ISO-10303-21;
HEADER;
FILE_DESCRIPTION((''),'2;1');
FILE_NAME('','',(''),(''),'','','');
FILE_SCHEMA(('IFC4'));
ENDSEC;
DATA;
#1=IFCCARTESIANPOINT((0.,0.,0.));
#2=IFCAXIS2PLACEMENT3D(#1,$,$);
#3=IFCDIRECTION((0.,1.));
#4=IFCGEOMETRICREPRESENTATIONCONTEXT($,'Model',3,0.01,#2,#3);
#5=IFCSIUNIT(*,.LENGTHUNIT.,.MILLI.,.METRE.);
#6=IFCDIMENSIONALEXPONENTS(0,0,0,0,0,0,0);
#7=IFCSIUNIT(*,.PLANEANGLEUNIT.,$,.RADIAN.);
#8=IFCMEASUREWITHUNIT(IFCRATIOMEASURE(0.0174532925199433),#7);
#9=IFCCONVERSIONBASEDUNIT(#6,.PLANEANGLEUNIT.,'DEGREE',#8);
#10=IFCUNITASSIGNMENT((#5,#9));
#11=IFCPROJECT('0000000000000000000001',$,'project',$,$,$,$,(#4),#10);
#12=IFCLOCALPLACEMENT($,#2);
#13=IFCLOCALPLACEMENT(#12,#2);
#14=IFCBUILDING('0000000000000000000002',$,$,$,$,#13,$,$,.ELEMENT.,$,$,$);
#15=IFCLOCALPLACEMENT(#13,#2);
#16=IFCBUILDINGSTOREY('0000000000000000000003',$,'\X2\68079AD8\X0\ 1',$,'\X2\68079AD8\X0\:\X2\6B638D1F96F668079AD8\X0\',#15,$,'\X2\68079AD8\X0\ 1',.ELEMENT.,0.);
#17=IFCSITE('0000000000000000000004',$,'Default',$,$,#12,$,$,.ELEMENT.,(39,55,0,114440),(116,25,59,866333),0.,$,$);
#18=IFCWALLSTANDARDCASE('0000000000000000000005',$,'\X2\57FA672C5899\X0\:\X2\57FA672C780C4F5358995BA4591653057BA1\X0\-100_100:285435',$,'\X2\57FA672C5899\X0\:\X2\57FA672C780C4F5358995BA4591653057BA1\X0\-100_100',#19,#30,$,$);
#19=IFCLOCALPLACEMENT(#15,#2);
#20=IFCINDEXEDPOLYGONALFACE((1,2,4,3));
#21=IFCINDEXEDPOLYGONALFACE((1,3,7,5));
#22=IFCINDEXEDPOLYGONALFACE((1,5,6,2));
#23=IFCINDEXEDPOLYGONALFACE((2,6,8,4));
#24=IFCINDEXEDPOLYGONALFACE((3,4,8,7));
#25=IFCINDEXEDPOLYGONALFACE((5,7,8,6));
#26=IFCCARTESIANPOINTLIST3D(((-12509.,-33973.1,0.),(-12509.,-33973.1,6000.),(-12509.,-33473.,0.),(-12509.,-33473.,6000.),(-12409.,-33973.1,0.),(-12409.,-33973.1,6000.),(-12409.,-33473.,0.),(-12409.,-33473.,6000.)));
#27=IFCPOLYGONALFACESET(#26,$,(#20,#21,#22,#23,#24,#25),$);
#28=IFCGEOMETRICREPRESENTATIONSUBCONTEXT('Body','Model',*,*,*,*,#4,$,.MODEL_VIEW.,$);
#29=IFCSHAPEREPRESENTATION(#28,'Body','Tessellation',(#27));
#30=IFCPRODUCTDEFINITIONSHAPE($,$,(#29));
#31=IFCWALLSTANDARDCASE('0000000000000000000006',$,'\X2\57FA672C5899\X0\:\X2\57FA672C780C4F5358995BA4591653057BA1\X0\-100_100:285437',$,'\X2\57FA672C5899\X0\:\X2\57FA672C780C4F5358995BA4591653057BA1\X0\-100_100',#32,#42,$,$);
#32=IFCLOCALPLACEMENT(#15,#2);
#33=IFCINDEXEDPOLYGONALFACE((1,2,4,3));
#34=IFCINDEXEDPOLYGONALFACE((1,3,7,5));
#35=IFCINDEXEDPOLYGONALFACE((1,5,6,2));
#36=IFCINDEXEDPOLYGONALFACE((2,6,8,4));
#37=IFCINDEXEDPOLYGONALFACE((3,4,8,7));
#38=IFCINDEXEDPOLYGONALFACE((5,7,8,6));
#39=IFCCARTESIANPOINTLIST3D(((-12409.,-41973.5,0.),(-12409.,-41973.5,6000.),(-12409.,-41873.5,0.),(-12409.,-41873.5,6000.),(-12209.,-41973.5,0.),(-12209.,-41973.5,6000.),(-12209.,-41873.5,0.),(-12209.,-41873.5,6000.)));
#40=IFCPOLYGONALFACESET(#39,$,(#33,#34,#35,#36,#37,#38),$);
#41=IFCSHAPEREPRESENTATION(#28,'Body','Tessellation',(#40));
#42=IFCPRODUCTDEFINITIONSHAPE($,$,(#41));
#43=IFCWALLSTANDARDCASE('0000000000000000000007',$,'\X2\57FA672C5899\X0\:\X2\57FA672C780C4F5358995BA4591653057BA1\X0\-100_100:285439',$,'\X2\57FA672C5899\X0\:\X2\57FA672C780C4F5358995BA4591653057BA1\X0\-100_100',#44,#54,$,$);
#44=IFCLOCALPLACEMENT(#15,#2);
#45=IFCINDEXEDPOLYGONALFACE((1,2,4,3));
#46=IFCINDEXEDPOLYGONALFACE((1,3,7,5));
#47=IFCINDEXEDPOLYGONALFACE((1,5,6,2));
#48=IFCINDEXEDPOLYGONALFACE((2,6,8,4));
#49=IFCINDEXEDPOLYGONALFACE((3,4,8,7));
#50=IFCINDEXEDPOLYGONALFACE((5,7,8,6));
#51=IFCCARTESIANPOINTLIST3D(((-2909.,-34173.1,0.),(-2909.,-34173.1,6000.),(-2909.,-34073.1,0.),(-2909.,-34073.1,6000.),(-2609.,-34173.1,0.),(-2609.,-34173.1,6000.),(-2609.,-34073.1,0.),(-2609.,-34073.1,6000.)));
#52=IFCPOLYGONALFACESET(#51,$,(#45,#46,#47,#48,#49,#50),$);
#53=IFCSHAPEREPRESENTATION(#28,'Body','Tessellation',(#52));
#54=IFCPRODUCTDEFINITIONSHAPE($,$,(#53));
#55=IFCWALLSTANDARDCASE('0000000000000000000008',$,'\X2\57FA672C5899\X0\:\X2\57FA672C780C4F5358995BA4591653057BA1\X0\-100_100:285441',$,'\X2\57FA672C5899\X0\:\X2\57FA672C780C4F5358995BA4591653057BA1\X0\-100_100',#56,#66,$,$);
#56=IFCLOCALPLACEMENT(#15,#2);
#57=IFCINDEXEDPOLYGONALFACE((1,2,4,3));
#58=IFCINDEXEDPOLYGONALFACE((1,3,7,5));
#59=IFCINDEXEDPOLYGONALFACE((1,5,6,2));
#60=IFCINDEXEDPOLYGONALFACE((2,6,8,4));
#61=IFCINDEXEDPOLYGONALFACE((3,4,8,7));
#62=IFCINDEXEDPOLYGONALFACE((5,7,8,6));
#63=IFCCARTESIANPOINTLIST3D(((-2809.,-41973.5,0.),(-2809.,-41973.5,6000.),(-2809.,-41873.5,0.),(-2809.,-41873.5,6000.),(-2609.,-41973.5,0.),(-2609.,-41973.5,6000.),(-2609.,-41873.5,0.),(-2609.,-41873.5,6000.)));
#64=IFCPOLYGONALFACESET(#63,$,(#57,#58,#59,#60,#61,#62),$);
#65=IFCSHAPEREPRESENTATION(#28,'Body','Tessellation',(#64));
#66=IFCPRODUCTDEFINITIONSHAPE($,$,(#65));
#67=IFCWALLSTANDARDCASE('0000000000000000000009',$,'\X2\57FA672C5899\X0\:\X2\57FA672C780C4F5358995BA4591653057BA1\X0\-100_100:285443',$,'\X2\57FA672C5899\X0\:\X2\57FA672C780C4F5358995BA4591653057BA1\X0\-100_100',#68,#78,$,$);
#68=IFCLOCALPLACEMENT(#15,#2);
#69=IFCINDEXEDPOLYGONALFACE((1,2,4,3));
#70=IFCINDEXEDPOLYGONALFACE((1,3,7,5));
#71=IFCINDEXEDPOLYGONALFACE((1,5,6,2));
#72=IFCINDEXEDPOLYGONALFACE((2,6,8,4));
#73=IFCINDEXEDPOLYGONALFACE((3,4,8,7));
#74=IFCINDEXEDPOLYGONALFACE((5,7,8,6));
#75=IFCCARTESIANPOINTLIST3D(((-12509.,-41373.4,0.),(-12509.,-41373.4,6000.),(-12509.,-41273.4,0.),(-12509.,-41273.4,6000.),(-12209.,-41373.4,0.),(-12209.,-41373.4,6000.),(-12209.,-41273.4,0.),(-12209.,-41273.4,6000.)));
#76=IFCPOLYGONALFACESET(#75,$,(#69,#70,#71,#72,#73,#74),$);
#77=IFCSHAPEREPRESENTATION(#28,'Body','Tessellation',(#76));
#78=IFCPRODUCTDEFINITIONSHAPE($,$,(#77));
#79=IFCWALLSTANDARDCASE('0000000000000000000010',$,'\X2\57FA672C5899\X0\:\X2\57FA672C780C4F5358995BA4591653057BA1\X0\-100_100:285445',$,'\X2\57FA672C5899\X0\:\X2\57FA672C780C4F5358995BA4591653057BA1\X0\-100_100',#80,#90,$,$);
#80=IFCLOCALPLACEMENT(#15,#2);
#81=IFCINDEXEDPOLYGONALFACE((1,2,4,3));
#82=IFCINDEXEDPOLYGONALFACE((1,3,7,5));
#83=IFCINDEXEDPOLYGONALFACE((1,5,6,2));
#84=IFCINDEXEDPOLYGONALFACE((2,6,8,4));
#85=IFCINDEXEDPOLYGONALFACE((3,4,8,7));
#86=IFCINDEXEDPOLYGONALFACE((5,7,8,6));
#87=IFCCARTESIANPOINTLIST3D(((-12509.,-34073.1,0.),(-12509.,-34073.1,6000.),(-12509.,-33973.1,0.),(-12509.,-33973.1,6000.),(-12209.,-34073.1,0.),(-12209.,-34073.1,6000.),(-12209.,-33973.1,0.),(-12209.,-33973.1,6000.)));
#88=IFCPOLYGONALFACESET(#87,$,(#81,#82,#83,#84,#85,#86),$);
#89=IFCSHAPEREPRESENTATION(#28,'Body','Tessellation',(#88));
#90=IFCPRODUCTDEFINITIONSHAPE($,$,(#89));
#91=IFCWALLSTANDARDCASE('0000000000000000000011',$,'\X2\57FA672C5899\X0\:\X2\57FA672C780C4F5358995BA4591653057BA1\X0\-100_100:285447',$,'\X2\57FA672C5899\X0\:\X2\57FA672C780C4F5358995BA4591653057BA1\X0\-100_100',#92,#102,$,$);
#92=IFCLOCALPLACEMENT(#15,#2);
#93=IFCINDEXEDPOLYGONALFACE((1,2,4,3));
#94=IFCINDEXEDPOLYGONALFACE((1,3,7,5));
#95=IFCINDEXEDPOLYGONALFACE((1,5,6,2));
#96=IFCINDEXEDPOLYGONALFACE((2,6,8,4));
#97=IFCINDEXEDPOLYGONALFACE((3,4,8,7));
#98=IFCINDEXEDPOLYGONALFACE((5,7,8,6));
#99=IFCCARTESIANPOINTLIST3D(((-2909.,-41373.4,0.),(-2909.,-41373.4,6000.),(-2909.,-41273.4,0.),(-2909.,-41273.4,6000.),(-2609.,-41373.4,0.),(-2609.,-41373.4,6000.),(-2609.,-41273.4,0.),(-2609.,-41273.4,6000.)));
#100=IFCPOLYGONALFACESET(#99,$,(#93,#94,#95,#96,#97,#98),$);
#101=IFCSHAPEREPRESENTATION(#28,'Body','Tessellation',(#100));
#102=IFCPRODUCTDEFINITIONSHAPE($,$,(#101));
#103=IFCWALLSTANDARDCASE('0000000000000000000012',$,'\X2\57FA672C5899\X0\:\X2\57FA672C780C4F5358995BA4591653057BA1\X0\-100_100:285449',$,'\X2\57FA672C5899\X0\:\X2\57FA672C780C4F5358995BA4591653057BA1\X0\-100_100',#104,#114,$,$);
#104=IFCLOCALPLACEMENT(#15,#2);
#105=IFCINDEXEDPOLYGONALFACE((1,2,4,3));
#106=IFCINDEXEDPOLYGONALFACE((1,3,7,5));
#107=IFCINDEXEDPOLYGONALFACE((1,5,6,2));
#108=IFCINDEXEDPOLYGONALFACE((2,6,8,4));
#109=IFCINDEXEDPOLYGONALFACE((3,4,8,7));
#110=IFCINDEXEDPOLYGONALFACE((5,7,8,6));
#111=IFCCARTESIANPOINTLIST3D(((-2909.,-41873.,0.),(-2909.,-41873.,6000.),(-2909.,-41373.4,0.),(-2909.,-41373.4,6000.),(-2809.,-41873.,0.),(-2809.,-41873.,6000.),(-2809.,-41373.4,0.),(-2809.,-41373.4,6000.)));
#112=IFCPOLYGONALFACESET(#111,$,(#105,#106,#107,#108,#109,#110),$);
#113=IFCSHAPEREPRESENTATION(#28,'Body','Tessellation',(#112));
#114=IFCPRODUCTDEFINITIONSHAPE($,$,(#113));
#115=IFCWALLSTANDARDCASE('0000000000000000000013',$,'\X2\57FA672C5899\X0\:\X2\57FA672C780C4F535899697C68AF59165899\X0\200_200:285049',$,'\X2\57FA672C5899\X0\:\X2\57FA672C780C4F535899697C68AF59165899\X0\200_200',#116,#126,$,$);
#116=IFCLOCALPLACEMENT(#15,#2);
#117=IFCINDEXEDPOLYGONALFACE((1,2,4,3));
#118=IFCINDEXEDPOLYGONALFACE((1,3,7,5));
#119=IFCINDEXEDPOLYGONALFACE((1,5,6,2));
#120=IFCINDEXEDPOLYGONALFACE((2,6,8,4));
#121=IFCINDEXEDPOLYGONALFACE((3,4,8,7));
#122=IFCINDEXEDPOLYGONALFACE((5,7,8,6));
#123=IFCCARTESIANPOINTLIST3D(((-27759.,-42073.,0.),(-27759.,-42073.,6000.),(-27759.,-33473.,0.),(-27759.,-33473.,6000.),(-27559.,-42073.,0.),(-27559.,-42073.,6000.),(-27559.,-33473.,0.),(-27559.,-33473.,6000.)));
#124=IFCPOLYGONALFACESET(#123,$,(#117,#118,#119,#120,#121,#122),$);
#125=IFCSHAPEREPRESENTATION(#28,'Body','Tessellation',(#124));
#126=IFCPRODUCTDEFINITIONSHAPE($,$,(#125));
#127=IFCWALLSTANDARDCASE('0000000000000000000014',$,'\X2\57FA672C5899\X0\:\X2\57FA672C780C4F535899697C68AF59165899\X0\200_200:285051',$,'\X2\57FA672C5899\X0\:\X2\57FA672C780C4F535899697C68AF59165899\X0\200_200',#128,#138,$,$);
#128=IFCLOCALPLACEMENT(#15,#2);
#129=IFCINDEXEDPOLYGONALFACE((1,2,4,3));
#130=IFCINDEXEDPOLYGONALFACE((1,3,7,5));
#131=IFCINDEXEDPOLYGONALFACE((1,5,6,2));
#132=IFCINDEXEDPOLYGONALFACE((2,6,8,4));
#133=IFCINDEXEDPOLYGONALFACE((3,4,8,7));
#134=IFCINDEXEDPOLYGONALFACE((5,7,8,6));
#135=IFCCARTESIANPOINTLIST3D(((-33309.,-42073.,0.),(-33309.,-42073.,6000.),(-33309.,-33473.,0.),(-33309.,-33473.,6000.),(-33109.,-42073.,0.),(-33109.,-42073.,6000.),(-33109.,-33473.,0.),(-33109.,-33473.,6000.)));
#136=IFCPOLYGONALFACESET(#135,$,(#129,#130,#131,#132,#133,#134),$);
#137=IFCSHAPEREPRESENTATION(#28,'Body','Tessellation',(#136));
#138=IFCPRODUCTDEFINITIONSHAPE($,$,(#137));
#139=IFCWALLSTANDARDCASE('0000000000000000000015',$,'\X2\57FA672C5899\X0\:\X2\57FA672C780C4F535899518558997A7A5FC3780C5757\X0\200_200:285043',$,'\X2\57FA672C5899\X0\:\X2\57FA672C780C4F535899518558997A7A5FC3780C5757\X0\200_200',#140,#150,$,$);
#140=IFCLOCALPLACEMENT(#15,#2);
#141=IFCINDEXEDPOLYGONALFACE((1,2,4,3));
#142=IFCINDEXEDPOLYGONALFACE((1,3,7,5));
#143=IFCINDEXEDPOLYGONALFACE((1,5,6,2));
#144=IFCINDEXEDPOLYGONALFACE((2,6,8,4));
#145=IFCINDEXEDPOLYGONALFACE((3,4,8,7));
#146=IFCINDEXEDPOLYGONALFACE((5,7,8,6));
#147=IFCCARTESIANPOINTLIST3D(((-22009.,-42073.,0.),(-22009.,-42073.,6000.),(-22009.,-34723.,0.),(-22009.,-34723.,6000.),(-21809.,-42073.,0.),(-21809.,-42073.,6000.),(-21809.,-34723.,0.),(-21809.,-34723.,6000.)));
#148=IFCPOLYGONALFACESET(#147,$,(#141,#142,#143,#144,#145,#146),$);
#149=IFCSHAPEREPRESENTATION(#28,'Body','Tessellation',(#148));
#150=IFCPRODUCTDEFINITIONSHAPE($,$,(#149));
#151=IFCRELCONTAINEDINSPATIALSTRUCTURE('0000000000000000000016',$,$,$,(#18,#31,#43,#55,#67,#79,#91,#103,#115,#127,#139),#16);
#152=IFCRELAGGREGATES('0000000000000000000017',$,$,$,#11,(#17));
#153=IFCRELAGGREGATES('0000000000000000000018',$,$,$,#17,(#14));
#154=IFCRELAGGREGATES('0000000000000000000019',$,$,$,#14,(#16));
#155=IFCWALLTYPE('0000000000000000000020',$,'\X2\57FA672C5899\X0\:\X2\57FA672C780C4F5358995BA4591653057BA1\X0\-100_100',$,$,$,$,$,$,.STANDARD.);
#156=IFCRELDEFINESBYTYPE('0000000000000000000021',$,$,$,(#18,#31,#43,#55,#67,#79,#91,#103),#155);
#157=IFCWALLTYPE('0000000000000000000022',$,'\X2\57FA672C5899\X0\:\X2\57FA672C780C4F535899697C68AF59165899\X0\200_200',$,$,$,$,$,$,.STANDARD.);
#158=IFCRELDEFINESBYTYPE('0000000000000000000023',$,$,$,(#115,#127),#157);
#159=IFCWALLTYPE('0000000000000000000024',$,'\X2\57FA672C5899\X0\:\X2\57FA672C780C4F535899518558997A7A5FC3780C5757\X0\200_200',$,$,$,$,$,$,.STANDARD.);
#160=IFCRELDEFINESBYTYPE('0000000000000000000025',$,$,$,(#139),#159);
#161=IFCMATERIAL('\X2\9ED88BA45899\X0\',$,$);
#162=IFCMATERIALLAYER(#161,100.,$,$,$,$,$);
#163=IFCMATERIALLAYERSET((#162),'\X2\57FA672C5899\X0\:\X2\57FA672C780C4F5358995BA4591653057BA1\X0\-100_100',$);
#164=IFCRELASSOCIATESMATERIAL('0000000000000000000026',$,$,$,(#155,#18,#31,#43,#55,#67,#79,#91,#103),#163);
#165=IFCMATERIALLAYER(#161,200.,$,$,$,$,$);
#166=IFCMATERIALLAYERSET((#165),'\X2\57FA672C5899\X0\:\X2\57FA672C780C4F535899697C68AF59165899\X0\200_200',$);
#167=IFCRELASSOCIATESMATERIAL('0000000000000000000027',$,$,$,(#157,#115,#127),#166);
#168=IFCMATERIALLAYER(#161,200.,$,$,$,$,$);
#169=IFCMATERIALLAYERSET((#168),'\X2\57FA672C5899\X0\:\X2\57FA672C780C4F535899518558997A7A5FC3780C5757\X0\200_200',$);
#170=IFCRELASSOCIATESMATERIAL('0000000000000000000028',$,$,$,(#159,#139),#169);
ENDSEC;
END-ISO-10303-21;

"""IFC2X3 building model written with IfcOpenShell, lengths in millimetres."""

from ifc_helpers import new_model, entity, si_unit, converted_unit, direction, frame, frame_2d, origin, place, context, subcontext, project, spatial, rectangle, extrude, material, layer, layer_set, layer_usage, type_object, element, save


model = new_model("IFC2X3")

# Units and contexts
model_context = context("Model", 3, precision=0.01, world=origin(), true_north=direction((0.0, 1.0)))
body_context = subcontext(model_context, "Body", "Model", "MODEL_VIEW")
ifc_project = project(units=[si_unit("LENGTHUNIT", "METRE", prefix="MILLI"), converted_unit("PLANEANGLEUNIT", "DEGREE", entity("IfcRatioMeasure", 0.0174532925199433), si_unit("PLANEANGLEUNIT", "RADIAN"), dimensions=[0, 0, 0, 0, 0, 0, 0])], contexts=[model_context])

# Site, building, storey
site_placement = place(None, origin())
site = spatial("IfcSite", under=ifc_project, at=site_placement, Name="Default", CompositionType="ELEMENT", RefLatitude=(39, 55, 0, 114440), RefLongitude=(116, 25, 59, 866333), RefElevation=0.0)
building_placement = place(site_placement, origin())
building = spatial("IfcBuilding", under=site, at=building_placement, CompositionType="ELEMENT")
storey_placement = place(building_placement, origin())
storey = spatial("IfcBuildingStorey", under=building, at=storey_placement, Name="标高 1", ObjectType="标高:正负零标高", LongName="标高 1", CompositionType="ELEMENT", Elevation=0.0)

# Walls
ifc_material = material(Name="默认墙")
ifc_layer_1 = layer(ifc_material, 100.0)
ifc_layer_set_1 = layer_set([ifc_layer_1], Name="基本墙:基本砌体墙室外包管-100_100")
wall_type_1 = type_object("IfcWallType", Name="基本墙:基本砌体墙室外包管-100_100", PredefinedType="STANDARD", material=ifc_layer_set_1)
ifc_layer_usage_1 = layer_usage(ifc_layer_set_1, "AXIS2", "NEGATIVE", 50.0)
wall_1_placement = place(building_placement, frame((-12459.0, -33473.0, 0.0), z_axis=(0.0, 0.0, 1.0), x_axis=(0.0, -1.0, 0.0)))
element("IfcWallStandardCase", 1, at=wall_1_placement, inside=storey, type_object=wall_type_1, material=ifc_layer_usage_1, Name="基本墙:基本砌体墙室外包管-100_100:285435", ObjectType="基本墙:基本砌体墙室外包管-100_100", context=body_context, shape_type="SweptSolid", body=[
    extrude(rectangle(XDim=500.1, YDim=100.0, at=frame_2d((250.0, 0.0), x_axis=(-1.0, 0.0))), origin(), (0.0, 0.0, 1.0), 6000.0),
])
ifc_layer_usage_2 = layer_usage(ifc_layer_set_1, "AXIS2", "NEGATIVE", 50.0)
wall_2_placement = place(building_placement, frame((-12409.0, -41923.5, 0.0)))
element("IfcWallStandardCase", 2, at=wall_2_placement, inside=storey, type_object=wall_type_1, material=ifc_layer_usage_2, Name="基本墙:基本砌体墙室外包管-100_100:285437", ObjectType="基本墙:基本砌体墙室外包管-100_100", context=body_context, shape_type="SweptSolid", body=[
    extrude(rectangle(XDim=200.0, YDim=100.0, at=frame_2d((100.0, 0.0), x_axis=(-1.0, 0.0))), origin(), (0.0, 0.0, 1.0), 6000.0),
])
ifc_layer_usage_3 = layer_usage(ifc_layer_set_1, "AXIS2", "NEGATIVE", 50.0)
wall_3_placement = place(building_placement, frame((-2909.0, -34123.1, 0.0)))
element("IfcWallStandardCase", 3, at=wall_3_placement, inside=storey, type_object=wall_type_1, material=ifc_layer_usage_3, Name="基本墙:基本砌体墙室外包管-100_100:285439", ObjectType="基本墙:基本砌体墙室外包管-100_100", context=body_context, shape_type="SweptSolid", body=[
    extrude(rectangle(XDim=300.0, YDim=100.0, at=frame_2d((150.0, 0.0), x_axis=(-1.0, 0.0))), origin(), (0.0, 0.0, 1.0), 6000.0),
])
ifc_layer_usage_4 = layer_usage(ifc_layer_set_1, "AXIS2", "NEGATIVE", 50.0)
wall_4_placement = place(building_placement, frame((-2809.0, -41923.5, 0.0)))
element("IfcWallStandardCase", 4, at=wall_4_placement, inside=storey, type_object=wall_type_1, material=ifc_layer_usage_4, Name="基本墙:基本砌体墙室外包管-100_100:285441", ObjectType="基本墙:基本砌体墙室外包管-100_100", context=body_context, shape_type="SweptSolid", body=[
    extrude(rectangle(XDim=200.0, YDim=100.0, at=frame_2d((100.0, 0.0), x_axis=(-1.0, 0.0))), origin(), (0.0, 0.0, 1.0), 6000.0),
])
ifc_layer_usage_5 = layer_usage(ifc_layer_set_1, "AXIS2", "NEGATIVE", 50.0)
wall_5_placement = place(building_placement, frame((-12509.0, -41323.4, 0.0)))
element("IfcWallStandardCase", 5, at=wall_5_placement, inside=storey, type_object=wall_type_1, material=ifc_layer_usage_5, Name="基本墙:基本砌体墙室外包管-100_100:285443", ObjectType="基本墙:基本砌体墙室外包管-100_100", context=body_context, shape_type="SweptSolid", body=[
    extrude(rectangle(XDim=300.0, YDim=100.0, at=frame_2d((150.0, 0.0), x_axis=(-1.0, 0.0))), origin(), (0.0, 0.0, 1.0), 6000.0),
])
ifc_layer_usage_6 = layer_usage(ifc_layer_set_1, "AXIS2", "NEGATIVE", 50.0)
wall_6_placement = place(building_placement, frame((-12509.0, -34023.1, 0.0)))
element("IfcWallStandardCase", 6, at=wall_6_placement, inside=storey, type_object=wall_type_1, material=ifc_layer_usage_6, Name="基本墙:基本砌体墙室外包管-100_100:285445", ObjectType="基本墙:基本砌体墙室外包管-100_100", context=body_context, shape_type="SweptSolid", body=[
    extrude(rectangle(XDim=300.0, YDim=100.0, at=frame_2d((150.0, 0.0), x_axis=(-1.0, 0.0))), origin(), (0.0, 0.0, 1.0), 6000.0),
])
ifc_layer_usage_7 = layer_usage(ifc_layer_set_1, "AXIS2", "NEGATIVE", 50.0)
wall_7_placement = place(building_placement, frame((-2909.0, -41323.4, 0.0)))
element("IfcWallStandardCase", 7, at=wall_7_placement, inside=storey, type_object=wall_type_1, material=ifc_layer_usage_7, Name="基本墙:基本砌体墙室外包管-100_100:285447", ObjectType="基本墙:基本砌体墙室外包管-100_100", context=body_context, shape_type="SweptSolid", body=[
    extrude(rectangle(XDim=300.0, YDim=100.0, at=frame_2d((150.0, 0.0), x_axis=(-1.0, 0.0))), origin(), (0.0, 0.0, 1.0), 6000.0),
])
ifc_layer_usage_8 = layer_usage(ifc_layer_set_1, "AXIS2", "NEGATIVE", 50.0)
wall_8_placement = place(building_placement, frame((-2859.0, -41373.4, 0.0), z_axis=(0.0, 0.0, 1.0), x_axis=(0.0, -1.0, 0.0)))
element("IfcWallStandardCase", 8, at=wall_8_placement, inside=storey, type_object=wall_type_1, material=ifc_layer_usage_8, Name="基本墙:基本砌体墙室外包管-100_100:285449", ObjectType="基本墙:基本砌体墙室外包管-100_100", context=body_context, shape_type="SweptSolid", body=[
    extrude(rectangle(XDim=499.6, YDim=100.0, at=frame_2d((249.8, 0.0), x_axis=(-1.0, 0.0))), origin(), (0.0, 0.0, 1.0), 6000.0),
])
ifc_layer_2 = layer(ifc_material, 200.0)
ifc_layer_set_2 = layer_set([ifc_layer_2], Name="基本墙:基本砌体墙楼梯外墙200_200")
ifc_layer_usage_9 = layer_usage(ifc_layer_set_2, "AXIS2", "NEGATIVE", 100.0)
wall_type_2 = type_object("IfcWallType", Name="基本墙:基本砌体墙楼梯外墙200_200", PredefinedType="STANDARD", material=ifc_layer_set_2)
wall_9_placement = place(building_placement, frame((-27659.0, -42073.0, 0.0), z_axis=(0.0, 0.0, 1.0), x_axis=(0.0, 1.0, 0.0)))
element("IfcWallStandardCase", 9, at=wall_9_placement, inside=storey, type_object=wall_type_2, material=ifc_layer_usage_9, Name="基本墙:基本砌体墙楼梯外墙200_200:285049", ObjectType="基本墙:基本砌体墙楼梯外墙200_200", context=body_context, shape_type="SweptSolid", body=[
    extrude(rectangle(XDim=8600.0, YDim=200.0, at=frame_2d((4300.0, 0.0), x_axis=(-1.0, 0.0))), origin(), (0.0, 0.0, 1.0), 6000.0),
])
ifc_layer_usage_10 = layer_usage(ifc_layer_set_2, "AXIS2", "NEGATIVE", 100.0)
wall_10_placement = place(building_placement, frame((-33209.0, -42073.0, 0.0), z_axis=(0.0, 0.0, 1.0), x_axis=(0.0, 1.0, 0.0)))
element("IfcWallStandardCase", 10, at=wall_10_placement, inside=storey, type_object=wall_type_2, material=ifc_layer_usage_10, Name="基本墙:基本砌体墙楼梯外墙200_200:285051", ObjectType="基本墙:基本砌体墙楼梯外墙200_200", context=body_context, shape_type="SweptSolid", body=[
    extrude(rectangle(XDim=8600.0, YDim=200.0, at=frame_2d((4300.0, 0.0), x_axis=(-1.0, 0.0))), origin(), (0.0, 0.0, 1.0), 6000.0),
])
ifc_layer_3 = layer(ifc_material, 200.0)
ifc_layer_set_3 = layer_set([ifc_layer_3], Name="基本墙:基本砌体墙内墙空心砌块200_200")
ifc_layer_usage_11 = layer_usage(ifc_layer_set_3, "AXIS2", "NEGATIVE", 100.0)
wall_type_3 = type_object("IfcWallType", Name="基本墙:基本砌体墙内墙空心砌块200_200", PredefinedType="STANDARD", material=ifc_layer_set_3)
wall_11_placement = place(building_placement, frame((-21909.0, -34723.0, 0.0), z_axis=(0.0, 0.0, 1.0), x_axis=(0.0, -1.0, 0.0)))
element("IfcWallStandardCase", 11, at=wall_11_placement, inside=storey, type_object=wall_type_3, material=ifc_layer_usage_11, Name="基本墙:基本砌体墙内墙空心砌块200_200:285043", ObjectType="基本墙:基本砌体墙内墙空心砌块200_200", context=body_context, shape_type="SweptSolid", body=[
    extrude(rectangle(XDim=7350.0, YDim=200.0, at=frame_2d((3675.0, 0.0), x_axis=(-1.0, 0.0))), origin(), (0.0, 0.0, 1.0), 6000.0),
])

save(model, "model.ifc")
